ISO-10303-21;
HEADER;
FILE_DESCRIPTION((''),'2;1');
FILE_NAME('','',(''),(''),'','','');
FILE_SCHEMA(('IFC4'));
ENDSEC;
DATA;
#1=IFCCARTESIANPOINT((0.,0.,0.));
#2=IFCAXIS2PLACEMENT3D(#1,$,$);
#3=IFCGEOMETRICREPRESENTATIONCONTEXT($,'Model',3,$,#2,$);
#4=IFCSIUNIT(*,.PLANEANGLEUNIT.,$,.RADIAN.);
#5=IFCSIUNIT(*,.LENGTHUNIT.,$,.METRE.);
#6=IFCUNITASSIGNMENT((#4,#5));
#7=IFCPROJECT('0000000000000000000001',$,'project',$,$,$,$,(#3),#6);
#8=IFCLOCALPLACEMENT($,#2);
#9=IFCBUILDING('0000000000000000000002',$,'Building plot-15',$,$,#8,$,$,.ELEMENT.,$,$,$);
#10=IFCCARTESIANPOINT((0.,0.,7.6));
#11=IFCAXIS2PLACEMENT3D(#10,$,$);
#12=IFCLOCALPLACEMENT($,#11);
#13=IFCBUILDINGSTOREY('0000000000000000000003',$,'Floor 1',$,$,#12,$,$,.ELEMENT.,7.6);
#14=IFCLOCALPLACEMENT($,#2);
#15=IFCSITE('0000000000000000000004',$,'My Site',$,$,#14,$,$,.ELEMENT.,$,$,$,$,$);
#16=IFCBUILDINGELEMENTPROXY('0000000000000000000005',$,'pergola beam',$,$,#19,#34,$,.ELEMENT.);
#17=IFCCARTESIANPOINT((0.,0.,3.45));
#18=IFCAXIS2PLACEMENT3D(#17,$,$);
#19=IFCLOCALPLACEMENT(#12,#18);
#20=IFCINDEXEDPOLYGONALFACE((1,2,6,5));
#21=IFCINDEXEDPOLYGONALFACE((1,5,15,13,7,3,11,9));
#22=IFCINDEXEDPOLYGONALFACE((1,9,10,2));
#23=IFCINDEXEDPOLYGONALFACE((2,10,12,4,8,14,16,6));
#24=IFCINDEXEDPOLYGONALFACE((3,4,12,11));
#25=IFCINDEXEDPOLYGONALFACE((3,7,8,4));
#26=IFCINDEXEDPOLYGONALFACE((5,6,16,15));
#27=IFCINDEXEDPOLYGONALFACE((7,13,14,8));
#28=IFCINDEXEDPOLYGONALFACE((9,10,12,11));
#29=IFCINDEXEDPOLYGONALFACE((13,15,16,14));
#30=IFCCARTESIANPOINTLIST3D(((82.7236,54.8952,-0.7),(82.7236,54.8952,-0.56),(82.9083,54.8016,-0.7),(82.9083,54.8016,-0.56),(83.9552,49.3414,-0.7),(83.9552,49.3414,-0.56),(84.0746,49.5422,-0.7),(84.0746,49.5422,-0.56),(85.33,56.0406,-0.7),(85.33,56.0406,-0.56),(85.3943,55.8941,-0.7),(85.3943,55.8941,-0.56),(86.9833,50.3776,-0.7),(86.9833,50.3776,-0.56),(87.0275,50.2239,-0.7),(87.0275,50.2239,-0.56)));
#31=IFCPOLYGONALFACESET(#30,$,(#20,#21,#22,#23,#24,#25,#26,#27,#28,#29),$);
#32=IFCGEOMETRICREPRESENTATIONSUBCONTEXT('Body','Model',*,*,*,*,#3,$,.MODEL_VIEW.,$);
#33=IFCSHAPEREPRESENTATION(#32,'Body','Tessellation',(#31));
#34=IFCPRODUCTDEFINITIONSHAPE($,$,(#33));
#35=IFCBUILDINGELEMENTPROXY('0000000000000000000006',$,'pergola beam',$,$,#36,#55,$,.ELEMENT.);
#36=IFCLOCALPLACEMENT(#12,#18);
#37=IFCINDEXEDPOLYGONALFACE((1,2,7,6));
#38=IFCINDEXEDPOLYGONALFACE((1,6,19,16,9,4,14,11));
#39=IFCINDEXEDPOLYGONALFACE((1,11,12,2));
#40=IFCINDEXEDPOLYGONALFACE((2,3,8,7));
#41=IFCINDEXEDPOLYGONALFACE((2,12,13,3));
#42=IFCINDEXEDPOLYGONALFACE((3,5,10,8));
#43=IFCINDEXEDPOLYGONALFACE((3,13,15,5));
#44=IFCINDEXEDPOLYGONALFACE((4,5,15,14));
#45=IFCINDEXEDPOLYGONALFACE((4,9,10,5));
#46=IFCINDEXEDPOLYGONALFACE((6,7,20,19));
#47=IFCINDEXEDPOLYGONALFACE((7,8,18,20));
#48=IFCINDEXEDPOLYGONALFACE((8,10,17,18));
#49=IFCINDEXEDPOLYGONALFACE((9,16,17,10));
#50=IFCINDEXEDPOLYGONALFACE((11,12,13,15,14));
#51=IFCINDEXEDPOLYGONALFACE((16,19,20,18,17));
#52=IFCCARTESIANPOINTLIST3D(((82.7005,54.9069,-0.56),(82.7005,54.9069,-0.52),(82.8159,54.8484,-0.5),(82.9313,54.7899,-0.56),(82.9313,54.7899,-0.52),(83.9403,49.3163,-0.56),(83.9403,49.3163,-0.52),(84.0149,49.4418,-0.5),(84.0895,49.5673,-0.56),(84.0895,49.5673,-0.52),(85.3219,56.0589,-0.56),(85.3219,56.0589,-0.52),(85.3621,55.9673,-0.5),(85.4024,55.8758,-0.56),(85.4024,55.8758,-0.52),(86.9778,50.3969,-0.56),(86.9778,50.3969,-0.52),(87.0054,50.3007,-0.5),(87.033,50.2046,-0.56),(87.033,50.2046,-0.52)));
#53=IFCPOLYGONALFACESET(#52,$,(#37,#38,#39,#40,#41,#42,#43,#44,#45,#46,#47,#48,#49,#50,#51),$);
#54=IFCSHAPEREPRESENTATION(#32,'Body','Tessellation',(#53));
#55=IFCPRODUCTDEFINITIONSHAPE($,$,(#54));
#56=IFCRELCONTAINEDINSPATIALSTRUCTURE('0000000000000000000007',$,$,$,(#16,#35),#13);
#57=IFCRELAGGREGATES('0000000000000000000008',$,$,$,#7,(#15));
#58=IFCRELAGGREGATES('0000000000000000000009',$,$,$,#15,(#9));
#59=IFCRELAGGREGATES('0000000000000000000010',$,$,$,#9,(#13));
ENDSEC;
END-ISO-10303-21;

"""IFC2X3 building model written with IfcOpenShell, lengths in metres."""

from ifc_helpers import new_model, entity, si_unit, frame, origin, place, context, subcontext, project, spatial, element, save


model = new_model("IFC2X3")

# Units and contexts
model_context = context("Model", 3, world=origin())
body_context = subcontext(model_context, "Body", "Model", "MODEL_VIEW")
ifc_project = project(units=[si_unit("PLANEANGLEUNIT", "RADIAN"), si_unit("LENGTHUNIT", "METRE")], contexts=[model_context])

# Site, building, storey
site_placement = place(None, origin())
site = spatial("IfcSite", under=ifc_project, at=site_placement, Name="My Site", CompositionType="ELEMENT")
building_placement = place(None, origin())
building = spatial("IfcBuilding", under=site, at=building_placement, Name="Building plot-15", CompositionType="ELEMENT")
storey_placement = place(None, frame((0.0, 0.0, 7.6)))
storey = spatial("IfcBuildingStorey", under=building, at=storey_placement, Name="Floor 1", CompositionType="ELEMENT", Elevation=7.6)

# Building element proxies
proxy_1_placement = place(storey_placement, frame((0.0, 0.0, 3.45)))
axis2_placement3_d_1 = entity("IfcAxis2Placement3D", entity("IfcCartesianPoint", [0.0, 0.0, 0.0]))
element("IfcBuildingElementProxy", 1, at=proxy_1_placement, inside=storey, Name="pergola beam", CompositionType="ELEMENT", context=body_context, shape_type="SweptSolid", held_by="IfcProductRepresentation", body=[
    entity("IfcSurfaceCurveSweptAreaSolid", entity("IfcArbitraryClosedProfileDef", "AREA", None, entity("IfcPolyline", [entity("IfcCartesianPoint", [-0.7, -0.08]), entity("IfcCartesianPoint", [-0.7, 0.08]), entity("IfcCartesianPoint", [-0.56, 0.08]), entity("IfcCartesianPoint", [-0.56, -0.08]), entity("IfcCartesianPoint", [-0.7, -0.08])])), axis2_placement3_d_1, entity("IfcPolyline", [entity("IfcCartesianPoint", [85.3621, 55.9673]), entity("IfcCartesianPoint", [82.8159, 54.8484]), entity("IfcCartesianPoint", [84.0149, 49.4418]), entity("IfcCartesianPoint", [87.0054, 50.3007])]), 0.0, 1.0, entity("IfcPlane", axis2_placement3_d_1)),
])
proxy_2_placement = place(storey_placement, frame((0.0, 0.0, 3.45)))
axis2_placement3_d_2 = entity("IfcAxis2Placement3D", entity("IfcCartesianPoint", [0.0, 0.0, 0.0]))
element("IfcBuildingElementProxy", 2, at=proxy_2_placement, inside=storey, Name="pergola beam", CompositionType="ELEMENT", context=body_context, shape_type="SweptSolid", held_by="IfcProductRepresentation", body=[
    entity("IfcSurfaceCurveSweptAreaSolid", entity("IfcArbitraryClosedProfileDef", "AREA", None, entity("IfcPolyline", [entity("IfcCartesianPoint", [-0.5, 0.0]), entity("IfcCartesianPoint", [-0.52, -0.1]), entity("IfcCartesianPoint", [-0.56, -0.1]), entity("IfcCartesianPoint", [-0.56, 0.1]), entity("IfcCartesianPoint", [-0.52, 0.1]), entity("IfcCartesianPoint", [-0.5, 0.0])])), axis2_placement3_d_2, entity("IfcPolyline", [entity("IfcCartesianPoint", [85.3621, 55.9673]), entity("IfcCartesianPoint", [82.8159, 54.8484]), entity("IfcCartesianPoint", [84.0149, 49.4418]), entity("IfcCartesianPoint", [87.0054, 50.3007])]), 0.0, 1.0, entity("IfcPlane", axis2_placement3_d_2)),
])

save(model, "model.ifc")
